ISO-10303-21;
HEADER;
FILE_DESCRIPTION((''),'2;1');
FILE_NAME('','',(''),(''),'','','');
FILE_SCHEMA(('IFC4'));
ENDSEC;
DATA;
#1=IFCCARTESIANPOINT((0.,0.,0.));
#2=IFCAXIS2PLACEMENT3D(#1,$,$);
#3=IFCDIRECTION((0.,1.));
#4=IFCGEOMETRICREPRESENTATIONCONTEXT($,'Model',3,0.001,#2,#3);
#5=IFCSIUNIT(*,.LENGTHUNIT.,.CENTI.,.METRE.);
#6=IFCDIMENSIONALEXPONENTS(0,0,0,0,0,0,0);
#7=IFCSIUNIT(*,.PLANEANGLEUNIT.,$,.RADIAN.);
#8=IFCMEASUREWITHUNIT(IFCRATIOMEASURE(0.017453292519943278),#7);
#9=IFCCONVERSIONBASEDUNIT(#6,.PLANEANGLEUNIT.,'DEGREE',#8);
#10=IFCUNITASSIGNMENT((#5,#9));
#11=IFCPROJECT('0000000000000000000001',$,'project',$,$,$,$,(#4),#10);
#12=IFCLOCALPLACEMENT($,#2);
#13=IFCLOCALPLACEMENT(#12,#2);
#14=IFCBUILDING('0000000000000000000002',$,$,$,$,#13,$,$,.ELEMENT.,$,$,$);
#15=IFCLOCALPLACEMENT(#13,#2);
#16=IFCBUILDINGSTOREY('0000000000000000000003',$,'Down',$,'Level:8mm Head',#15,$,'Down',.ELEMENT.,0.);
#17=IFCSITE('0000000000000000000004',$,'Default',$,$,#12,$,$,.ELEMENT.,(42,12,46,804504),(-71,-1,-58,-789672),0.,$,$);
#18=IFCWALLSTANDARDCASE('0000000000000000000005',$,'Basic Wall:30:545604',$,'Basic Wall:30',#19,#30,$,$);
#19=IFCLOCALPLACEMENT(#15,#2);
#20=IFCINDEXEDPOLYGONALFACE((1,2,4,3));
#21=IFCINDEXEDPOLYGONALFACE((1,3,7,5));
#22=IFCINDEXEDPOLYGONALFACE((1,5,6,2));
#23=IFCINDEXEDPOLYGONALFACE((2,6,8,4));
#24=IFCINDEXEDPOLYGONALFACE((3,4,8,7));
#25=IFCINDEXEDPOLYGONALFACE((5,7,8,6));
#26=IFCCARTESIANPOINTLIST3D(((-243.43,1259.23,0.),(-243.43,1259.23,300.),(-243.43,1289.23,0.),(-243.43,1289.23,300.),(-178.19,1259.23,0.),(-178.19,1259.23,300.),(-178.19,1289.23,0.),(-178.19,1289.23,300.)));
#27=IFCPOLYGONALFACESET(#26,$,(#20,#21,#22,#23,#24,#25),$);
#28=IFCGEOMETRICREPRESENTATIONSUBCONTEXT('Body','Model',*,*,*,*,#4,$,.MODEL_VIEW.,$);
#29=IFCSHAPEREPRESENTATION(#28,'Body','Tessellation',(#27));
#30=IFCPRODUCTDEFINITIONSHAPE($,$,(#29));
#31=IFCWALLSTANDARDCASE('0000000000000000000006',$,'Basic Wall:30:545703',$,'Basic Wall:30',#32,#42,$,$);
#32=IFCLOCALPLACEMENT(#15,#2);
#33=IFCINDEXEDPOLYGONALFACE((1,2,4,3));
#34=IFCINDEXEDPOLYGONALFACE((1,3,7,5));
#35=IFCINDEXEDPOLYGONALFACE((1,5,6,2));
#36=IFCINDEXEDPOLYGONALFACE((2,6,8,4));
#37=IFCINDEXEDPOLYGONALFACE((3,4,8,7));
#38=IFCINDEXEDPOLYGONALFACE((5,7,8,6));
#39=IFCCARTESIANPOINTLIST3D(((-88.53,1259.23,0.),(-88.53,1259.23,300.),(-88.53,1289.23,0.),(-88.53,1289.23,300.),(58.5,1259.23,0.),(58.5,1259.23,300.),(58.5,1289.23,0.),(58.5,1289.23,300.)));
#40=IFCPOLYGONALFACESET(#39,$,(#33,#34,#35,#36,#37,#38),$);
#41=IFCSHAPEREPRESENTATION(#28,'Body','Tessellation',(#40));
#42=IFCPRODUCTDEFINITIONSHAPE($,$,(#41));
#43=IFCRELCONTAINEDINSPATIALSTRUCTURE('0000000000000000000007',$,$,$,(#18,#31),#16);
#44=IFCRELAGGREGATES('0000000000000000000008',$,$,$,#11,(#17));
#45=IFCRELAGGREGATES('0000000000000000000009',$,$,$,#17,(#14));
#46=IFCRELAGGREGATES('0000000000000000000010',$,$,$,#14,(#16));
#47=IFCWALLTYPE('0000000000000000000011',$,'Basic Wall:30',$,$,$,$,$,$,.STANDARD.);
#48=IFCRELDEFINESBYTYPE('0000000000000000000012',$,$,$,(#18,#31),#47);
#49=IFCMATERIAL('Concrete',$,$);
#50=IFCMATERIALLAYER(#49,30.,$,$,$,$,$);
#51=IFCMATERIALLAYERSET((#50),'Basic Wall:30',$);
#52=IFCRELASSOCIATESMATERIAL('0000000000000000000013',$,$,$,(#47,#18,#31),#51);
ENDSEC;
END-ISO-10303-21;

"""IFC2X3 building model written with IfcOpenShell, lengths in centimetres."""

from ifc_helpers import new_model, entity, si_unit, converted_unit, direction, frame, frame_2d, origin, place, context, subcontext, project, spatial, rectangle, extrude, material, layer, layer_set, layer_usage, type_object, element, save


model = new_model("IFC2X3")

# Units and contexts
model_context = context("Model", 3, precision=0.001, world=origin(), true_north=direction((0.0, 1.0)))
body_context = subcontext(model_context, "Body", "Model", "MODEL_VIEW")
ifc_project = project(units=[si_unit("LENGTHUNIT", "METRE", prefix="CENTI"), converted_unit("PLANEANGLEUNIT", "DEGREE", entity("IfcRatioMeasure", 0.017453292519943278), si_unit("PLANEANGLEUNIT", "RADIAN"), dimensions=[0, 0, 0, 0, 0, 0, 0])], contexts=[model_context])

# Site, building, storey
site_placement = place(None, origin())
site = spatial("IfcSite", under=ifc_project, at=site_placement, Name="Default", CompositionType="ELEMENT", RefLatitude=(42, 12, 46, 804504), RefLongitude=(-71, -1, -58, -789672), RefElevation=0.0)
building_placement = place(site_placement, origin())
building = spatial("IfcBuilding", under=site, at=building_placement, CompositionType="ELEMENT")
storey_placement = place(building_placement, origin())
storey = spatial("IfcBuildingStorey", under=building, at=storey_placement, Name="Down", ObjectType="Level:8mm Head", LongName="Down", CompositionType="ELEMENT", Elevation=0.0)

# Walls
ifc_material = material(Name="Concrete")
ifc_layer_1 = layer(ifc_material, 30.0)
ifc_layer_set_1 = layer_set([ifc_layer_1], Name="Basic Wall:30")
ifc_layer_usage_1 = layer_usage(ifc_layer_set_1, "AXIS2", "NEGATIVE", 15.0)
wall_type_1 = type_object("IfcWallType", Name="Basic Wall:30", PredefinedType="STANDARD", material=ifc_layer_set_1)
wall_1_placement = place(storey_placement, frame((-243.43, 1274.23, 0.0)))
element("IfcWallStandardCase", 1, at=wall_1_placement, inside=storey, type_object=wall_type_1, material=ifc_layer_usage_1, Name="Basic Wall:30:545604", ObjectType="Basic Wall:30", context=body_context, shape_type="SweptSolid", body=[
    extrude(rectangle(XDim=65.24, YDim=30.0, at=frame_2d((32.62, 0.0), x_axis=(-1.0, 0.0))), origin(), (0.0, 0.0, 1.0), 300.0),
])
ifc_layer_usage_2 = layer_usage(ifc_layer_set_1, "AXIS2", "NEGATIVE", 15.0)
wall_2_placement = place(storey_placement, frame((-88.53, 1274.23, 0.0)))
element("IfcWallStandardCase", 2, at=wall_2_placement, inside=storey, type_object=wall_type_1, material=ifc_layer_usage_2, Name="Basic Wall:30:545703", ObjectType="Basic Wall:30", context=body_context, shape_type="SweptSolid", body=[
    extrude(rectangle(XDim=147.03, YDim=30.0, at=frame_2d((73.51, 0.0), x_axis=(-1.0, 0.0))), origin(), (0.0, 0.0, 1.0), 300.0),
])

save(model, "model.ifc")
